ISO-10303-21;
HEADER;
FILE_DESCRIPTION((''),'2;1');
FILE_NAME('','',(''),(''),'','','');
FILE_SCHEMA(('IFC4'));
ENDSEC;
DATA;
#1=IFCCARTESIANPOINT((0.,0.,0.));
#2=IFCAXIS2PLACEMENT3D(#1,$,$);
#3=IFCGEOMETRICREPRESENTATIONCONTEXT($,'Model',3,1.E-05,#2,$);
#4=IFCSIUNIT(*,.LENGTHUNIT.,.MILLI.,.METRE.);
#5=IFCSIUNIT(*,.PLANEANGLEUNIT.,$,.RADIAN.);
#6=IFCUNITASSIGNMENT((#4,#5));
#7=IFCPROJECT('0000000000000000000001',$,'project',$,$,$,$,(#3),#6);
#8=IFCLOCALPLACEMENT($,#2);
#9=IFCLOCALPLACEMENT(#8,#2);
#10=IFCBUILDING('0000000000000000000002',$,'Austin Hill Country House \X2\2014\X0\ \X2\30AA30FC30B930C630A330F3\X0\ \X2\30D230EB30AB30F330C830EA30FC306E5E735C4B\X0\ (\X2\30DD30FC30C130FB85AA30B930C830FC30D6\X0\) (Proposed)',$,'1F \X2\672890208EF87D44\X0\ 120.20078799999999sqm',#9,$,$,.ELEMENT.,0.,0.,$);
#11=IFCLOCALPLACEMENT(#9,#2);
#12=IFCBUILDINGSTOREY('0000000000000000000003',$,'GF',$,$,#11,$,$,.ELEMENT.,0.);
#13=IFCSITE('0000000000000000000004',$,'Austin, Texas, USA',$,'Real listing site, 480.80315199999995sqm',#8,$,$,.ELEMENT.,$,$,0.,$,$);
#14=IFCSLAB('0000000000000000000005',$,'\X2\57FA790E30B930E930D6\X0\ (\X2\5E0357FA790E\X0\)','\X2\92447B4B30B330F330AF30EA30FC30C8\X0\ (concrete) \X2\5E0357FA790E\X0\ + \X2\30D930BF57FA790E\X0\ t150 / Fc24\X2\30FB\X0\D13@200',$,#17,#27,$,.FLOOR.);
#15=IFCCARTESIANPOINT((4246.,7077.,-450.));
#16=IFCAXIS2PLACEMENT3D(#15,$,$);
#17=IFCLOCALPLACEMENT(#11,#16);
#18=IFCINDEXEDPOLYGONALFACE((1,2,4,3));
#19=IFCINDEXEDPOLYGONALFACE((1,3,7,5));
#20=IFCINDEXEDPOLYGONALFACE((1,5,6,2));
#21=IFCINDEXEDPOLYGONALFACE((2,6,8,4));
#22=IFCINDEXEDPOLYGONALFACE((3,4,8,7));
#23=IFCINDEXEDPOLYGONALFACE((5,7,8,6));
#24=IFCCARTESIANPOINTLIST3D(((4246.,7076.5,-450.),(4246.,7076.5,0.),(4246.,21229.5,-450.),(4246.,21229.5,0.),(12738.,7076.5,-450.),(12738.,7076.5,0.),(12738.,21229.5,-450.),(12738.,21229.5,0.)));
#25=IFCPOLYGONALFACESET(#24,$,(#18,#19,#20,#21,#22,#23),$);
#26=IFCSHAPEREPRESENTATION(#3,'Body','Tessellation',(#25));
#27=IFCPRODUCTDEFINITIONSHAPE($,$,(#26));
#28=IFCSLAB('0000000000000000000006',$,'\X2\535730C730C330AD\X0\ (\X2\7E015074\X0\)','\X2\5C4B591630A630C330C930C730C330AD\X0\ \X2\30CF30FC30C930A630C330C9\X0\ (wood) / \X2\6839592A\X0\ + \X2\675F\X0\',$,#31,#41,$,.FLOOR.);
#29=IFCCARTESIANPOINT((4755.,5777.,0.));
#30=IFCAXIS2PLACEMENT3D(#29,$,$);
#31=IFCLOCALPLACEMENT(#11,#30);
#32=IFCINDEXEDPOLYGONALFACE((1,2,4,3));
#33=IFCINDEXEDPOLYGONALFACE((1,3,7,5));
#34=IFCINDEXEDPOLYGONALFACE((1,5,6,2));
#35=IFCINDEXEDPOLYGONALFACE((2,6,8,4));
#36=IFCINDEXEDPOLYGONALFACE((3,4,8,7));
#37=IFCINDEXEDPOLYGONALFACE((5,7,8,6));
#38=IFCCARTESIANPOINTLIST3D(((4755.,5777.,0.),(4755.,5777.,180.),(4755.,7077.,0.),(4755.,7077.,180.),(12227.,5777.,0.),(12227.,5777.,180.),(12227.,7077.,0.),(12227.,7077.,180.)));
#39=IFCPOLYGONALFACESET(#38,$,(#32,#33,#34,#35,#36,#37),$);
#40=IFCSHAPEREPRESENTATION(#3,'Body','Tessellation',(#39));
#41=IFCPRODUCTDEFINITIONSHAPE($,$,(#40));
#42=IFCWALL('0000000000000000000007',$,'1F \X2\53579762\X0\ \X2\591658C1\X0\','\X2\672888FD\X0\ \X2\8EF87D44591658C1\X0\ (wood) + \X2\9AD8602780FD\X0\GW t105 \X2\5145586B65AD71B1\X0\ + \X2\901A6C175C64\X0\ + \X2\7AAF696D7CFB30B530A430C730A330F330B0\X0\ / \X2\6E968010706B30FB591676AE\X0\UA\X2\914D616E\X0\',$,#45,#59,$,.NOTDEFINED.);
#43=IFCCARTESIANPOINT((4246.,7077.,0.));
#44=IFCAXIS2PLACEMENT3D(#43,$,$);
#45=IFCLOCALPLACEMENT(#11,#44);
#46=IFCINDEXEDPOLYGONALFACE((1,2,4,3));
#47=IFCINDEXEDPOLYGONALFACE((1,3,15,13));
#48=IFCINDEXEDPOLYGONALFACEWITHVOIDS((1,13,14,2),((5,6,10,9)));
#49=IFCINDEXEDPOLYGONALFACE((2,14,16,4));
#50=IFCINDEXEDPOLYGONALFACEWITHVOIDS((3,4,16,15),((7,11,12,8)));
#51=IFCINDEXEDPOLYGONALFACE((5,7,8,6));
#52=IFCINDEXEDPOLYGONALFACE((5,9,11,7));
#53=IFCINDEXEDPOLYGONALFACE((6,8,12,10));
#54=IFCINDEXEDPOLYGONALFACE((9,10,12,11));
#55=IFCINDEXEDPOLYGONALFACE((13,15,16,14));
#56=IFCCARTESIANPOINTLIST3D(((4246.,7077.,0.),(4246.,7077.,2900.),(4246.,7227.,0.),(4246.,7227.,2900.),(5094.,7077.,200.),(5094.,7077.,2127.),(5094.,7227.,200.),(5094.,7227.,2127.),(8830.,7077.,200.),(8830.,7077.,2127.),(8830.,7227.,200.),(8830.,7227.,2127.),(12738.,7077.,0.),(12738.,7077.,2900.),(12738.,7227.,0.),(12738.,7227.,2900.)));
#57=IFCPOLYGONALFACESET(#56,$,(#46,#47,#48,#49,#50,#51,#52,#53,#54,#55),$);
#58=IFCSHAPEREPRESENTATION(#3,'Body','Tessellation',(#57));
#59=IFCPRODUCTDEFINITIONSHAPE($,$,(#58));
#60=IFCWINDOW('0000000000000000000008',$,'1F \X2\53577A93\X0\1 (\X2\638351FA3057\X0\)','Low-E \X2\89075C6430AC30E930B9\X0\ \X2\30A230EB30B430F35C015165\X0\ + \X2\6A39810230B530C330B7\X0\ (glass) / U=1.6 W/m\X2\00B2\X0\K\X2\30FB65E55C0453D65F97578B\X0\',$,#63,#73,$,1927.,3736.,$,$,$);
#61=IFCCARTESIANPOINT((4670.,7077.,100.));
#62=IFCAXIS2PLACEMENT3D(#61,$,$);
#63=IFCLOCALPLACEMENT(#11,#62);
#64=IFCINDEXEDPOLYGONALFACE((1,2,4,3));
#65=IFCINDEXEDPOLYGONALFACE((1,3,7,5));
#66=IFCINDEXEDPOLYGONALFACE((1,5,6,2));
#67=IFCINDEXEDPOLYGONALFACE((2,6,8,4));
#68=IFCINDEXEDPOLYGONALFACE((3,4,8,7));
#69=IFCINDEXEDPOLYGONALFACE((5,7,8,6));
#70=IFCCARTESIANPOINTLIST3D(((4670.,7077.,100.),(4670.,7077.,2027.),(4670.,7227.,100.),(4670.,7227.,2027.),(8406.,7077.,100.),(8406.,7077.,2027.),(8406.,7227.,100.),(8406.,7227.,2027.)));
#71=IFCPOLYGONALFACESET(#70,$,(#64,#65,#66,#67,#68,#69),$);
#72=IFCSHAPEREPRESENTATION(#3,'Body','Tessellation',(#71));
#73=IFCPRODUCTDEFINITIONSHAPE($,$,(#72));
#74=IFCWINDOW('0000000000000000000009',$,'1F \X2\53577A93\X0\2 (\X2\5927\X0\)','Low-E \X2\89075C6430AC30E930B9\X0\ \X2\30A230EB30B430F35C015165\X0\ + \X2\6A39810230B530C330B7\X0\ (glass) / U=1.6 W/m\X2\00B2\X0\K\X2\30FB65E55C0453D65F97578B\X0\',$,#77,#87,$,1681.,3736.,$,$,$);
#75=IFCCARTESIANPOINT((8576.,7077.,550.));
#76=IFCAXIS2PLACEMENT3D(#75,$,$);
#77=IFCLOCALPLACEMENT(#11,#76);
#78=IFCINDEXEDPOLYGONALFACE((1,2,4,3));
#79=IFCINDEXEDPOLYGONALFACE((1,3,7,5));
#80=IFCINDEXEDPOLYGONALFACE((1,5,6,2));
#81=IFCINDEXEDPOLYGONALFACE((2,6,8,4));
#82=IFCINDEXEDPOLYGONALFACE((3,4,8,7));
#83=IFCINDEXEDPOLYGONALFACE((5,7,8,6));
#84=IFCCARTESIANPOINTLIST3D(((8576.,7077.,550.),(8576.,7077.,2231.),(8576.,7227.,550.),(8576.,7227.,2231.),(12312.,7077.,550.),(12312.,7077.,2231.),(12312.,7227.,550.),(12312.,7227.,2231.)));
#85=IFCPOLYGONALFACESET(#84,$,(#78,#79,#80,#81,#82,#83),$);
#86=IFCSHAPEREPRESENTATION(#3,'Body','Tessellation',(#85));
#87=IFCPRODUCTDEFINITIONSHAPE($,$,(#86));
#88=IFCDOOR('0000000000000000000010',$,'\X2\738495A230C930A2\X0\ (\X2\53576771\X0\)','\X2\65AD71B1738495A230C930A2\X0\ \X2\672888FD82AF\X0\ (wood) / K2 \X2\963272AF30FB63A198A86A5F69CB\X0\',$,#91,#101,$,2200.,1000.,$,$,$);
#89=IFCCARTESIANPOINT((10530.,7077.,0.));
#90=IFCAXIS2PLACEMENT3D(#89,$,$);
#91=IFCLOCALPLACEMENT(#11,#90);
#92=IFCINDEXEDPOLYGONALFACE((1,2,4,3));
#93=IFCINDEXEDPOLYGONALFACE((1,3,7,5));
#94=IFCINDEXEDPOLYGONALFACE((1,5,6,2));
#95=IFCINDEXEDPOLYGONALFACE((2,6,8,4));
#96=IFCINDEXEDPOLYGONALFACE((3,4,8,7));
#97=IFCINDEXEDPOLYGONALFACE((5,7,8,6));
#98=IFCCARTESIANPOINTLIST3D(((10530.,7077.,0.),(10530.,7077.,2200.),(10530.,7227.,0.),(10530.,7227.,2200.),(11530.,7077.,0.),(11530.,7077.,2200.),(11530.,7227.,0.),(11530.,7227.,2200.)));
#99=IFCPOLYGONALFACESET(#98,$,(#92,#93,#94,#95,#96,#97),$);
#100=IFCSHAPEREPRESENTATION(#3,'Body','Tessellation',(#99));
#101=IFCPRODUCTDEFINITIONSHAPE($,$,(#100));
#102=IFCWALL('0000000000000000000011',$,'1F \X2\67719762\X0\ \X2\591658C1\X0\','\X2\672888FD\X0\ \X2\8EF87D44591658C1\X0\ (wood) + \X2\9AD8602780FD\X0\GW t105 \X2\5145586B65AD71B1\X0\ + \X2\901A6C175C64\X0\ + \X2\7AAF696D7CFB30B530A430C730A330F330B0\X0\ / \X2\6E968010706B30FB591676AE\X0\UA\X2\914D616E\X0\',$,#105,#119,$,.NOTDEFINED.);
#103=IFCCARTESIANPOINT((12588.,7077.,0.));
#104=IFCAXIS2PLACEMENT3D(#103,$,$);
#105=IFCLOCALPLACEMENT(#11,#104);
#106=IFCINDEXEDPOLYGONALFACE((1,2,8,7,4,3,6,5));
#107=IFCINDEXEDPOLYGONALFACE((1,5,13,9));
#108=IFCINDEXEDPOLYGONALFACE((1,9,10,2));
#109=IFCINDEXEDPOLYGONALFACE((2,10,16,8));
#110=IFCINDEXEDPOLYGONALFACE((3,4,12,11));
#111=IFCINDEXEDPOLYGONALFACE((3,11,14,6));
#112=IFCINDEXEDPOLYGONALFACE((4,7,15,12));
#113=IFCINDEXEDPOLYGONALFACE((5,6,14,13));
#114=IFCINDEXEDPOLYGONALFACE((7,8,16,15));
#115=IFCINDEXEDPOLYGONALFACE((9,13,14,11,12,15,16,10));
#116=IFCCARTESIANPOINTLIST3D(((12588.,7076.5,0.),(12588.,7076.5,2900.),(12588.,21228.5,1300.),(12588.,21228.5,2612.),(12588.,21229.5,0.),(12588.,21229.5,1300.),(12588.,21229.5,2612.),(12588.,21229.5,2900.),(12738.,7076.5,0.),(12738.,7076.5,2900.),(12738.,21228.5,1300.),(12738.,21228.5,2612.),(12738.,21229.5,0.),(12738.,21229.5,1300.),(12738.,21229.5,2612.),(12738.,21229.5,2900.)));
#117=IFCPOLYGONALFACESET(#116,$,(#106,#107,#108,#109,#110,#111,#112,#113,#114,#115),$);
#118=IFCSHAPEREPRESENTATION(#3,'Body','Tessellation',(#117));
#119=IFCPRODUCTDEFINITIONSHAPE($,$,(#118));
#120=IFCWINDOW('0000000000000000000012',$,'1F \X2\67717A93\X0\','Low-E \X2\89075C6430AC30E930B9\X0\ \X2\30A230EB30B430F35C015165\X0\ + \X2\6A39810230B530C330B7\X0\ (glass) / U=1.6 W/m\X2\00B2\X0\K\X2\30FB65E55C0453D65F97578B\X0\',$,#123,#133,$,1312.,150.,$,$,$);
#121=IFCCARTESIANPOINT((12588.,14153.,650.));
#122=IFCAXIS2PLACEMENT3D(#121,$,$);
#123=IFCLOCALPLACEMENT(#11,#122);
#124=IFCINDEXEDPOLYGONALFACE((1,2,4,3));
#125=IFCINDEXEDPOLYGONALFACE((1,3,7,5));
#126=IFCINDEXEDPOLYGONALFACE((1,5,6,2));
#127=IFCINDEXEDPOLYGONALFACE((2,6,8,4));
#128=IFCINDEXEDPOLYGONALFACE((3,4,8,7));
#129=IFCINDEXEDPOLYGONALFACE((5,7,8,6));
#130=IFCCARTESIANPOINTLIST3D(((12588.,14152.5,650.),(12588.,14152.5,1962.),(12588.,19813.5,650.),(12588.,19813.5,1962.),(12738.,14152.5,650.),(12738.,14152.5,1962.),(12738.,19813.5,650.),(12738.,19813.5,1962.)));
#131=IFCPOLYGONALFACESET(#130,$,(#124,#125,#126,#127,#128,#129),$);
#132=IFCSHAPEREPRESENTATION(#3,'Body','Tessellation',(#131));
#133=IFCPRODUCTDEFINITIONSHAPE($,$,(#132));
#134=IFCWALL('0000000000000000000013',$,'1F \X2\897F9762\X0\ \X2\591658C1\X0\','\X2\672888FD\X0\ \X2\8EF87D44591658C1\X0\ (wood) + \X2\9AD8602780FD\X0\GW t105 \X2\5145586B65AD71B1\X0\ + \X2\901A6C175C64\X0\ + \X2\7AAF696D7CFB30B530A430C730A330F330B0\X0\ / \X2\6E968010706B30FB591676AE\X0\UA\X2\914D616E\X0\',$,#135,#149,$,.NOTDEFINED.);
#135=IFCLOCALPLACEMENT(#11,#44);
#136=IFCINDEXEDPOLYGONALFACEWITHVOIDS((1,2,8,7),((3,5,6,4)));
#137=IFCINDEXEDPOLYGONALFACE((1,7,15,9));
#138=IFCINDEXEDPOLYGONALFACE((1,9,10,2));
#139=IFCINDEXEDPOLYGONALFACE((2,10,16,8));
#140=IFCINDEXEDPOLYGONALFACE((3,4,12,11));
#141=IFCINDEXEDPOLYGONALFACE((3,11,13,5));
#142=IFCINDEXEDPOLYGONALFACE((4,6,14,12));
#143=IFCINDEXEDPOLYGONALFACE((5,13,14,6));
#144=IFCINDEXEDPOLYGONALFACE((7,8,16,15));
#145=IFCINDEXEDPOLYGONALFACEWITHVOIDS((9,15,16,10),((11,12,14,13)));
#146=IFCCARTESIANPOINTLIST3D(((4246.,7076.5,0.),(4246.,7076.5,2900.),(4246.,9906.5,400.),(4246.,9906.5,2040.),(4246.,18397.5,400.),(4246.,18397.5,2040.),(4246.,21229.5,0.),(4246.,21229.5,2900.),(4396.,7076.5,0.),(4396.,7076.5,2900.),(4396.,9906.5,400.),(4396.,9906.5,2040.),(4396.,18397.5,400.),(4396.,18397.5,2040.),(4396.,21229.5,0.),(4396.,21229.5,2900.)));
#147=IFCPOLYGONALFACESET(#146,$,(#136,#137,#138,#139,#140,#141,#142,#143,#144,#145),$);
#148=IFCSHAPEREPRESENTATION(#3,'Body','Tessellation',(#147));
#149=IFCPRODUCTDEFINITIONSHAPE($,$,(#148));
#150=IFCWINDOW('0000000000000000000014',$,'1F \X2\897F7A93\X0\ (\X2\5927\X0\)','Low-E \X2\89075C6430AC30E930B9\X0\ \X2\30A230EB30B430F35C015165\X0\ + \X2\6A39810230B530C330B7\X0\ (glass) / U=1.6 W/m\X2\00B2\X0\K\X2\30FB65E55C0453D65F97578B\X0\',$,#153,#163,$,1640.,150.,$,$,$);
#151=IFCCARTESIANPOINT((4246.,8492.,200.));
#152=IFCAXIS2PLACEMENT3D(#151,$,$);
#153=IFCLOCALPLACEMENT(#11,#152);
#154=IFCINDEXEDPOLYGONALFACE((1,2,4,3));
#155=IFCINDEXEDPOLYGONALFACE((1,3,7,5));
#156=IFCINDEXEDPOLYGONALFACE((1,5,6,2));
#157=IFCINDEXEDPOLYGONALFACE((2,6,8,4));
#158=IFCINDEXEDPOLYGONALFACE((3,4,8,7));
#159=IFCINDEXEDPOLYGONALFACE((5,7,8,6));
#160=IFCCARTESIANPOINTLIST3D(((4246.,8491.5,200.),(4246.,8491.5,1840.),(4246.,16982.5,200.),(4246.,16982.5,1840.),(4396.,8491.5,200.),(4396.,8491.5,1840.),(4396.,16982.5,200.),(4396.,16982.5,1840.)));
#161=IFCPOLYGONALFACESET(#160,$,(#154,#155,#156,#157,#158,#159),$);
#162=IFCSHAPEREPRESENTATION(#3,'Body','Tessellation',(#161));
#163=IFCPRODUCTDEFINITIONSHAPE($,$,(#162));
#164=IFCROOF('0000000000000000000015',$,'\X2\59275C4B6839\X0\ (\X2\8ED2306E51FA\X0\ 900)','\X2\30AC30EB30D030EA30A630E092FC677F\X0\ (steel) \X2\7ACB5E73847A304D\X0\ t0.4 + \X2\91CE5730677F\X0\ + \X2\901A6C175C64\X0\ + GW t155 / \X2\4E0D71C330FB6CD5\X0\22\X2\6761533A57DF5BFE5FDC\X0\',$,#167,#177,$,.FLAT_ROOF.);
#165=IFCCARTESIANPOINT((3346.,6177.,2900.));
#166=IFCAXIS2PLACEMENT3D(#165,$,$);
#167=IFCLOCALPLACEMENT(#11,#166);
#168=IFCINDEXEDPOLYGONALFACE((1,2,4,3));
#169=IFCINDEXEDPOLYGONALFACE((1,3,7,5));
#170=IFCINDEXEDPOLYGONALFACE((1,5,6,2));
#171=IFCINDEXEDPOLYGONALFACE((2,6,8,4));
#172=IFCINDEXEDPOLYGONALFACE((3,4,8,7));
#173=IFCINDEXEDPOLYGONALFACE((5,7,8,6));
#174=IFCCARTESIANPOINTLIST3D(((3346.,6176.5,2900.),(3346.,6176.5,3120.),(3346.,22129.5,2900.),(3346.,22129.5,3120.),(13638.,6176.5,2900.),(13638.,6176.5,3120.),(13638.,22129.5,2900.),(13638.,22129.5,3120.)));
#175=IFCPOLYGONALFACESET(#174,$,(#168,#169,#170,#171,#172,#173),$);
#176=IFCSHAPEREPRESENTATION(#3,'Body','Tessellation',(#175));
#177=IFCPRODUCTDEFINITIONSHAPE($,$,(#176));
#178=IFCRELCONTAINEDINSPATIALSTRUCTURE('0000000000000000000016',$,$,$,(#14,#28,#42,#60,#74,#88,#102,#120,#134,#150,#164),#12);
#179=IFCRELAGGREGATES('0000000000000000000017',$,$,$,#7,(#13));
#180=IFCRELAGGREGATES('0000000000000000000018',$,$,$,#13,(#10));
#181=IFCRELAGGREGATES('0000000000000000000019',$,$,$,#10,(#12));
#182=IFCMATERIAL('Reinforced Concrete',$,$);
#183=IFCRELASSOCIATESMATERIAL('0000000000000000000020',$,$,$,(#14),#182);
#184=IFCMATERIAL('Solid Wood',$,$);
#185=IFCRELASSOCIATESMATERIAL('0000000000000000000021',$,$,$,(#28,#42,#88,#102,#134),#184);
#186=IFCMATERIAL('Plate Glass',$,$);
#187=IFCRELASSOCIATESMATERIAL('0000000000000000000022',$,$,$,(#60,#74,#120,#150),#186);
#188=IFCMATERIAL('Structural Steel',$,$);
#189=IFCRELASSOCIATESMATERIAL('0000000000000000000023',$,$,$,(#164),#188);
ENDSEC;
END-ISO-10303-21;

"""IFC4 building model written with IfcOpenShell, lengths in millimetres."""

from ifc_helpers import new_model, si_unit, frame, frame_2d, origin, place, context, project, spatial, rectangle, extrude, material, element, fill, save


model = new_model("IFC4")

# Units and contexts
model_context = context("Model", 3, precision=1e-05, world=origin())
ifc_project = project(units=[si_unit("LENGTHUNIT", "METRE", prefix="MILLI"), si_unit("PLANEANGLEUNIT", "RADIAN")], contexts=[model_context])

# Site, building, storey
site_placement = place(None, origin())
site = spatial("IfcSite", under=ifc_project, at=site_placement, Name="Austin, Texas, USA", ObjectType="Real listing site, 480.80315199999995sqm", CompositionType="ELEMENT", RefElevation=0.0)
building_placement = place(site_placement, origin())
building = spatial("IfcBuilding", under=site, at=building_placement, Name="Austin Hill Country House — オースティン ヒルカントリーの平屋 (ポーチ・薪ストーブ) (Proposed)", ObjectType="1F 木造軸組 120.20078799999999sqm", CompositionType="ELEMENT", ElevationOfRefHeight=0.0, ElevationOfTerrain=0.0)
storey_placement = place(building_placement, origin())
storey = spatial("IfcBuildingStorey", under=building, at=storey_placement, Name="GF", CompositionType="ELEMENT", Elevation=0.0)

# Slabs
ifc_material_1 = material(Name="Reinforced Concrete")
slab_1_placement = place(storey_placement, frame((4246.0, 7077.0, -450.0)))
element("IfcSlab", 1, at=slab_1_placement, inside=storey, material=ifc_material_1, Name="基礎スラブ (布基礎)", Description="鉄筋コンクリート (concrete) 布基礎 + ベタ基礎 t150 / Fc24・D13@200", PredefinedType="FLOOR", context=model_context, shape_type="SweptSolid", body=[
    extrude(rectangle(XDim=8492.0, YDim=14153.0, at=frame_2d((4246.0, 7076.0))), frame((4246.0, 7077.0, -450.0)), (0.0, 0.0, 1.0), 450.0),
])
ifc_material_2 = material(Name="Solid Wood")
slab_2_placement = place(storey_placement, frame((4755.0, 5777.0, 0.0)))
element("IfcSlab", 2, at=slab_2_placement, inside=storey, material=ifc_material_2, Name="南デッキ (縁側)", Description="屋外ウッドデッキ ハードウッド (wood) / 根太 + 束", PredefinedType="FLOOR", context=model_context, shape_type="SweptSolid", body=[
    extrude(rectangle(XDim=7472.0, YDim=1300.0, at=frame_2d((3736.0, 650.0))), frame((4755.0, 5777.0, 0.0)), (0.0, 0.0, 1.0), 180.0),
])

# Wall, openings, windows, door
wall_1_placement = place(storey_placement, frame((4246.0, 7077.0, 0.0)))
wall_1 = element("IfcWall", 3, at=wall_1_placement, inside=storey, material=ifc_material_2, Name="1F 南面 外壁", Description="木製 軸組外壁 (wood) + 高性能GW t105 充填断熱 + 通気層 + 窯業系サイディング / 準耐火・外皮UA配慮", PredefinedType="NOTDEFINED", context=model_context, shape_type="SweptSolid", body=[
    extrude(rectangle(XDim=8492.0, YDim=150.0, at=frame_2d((4246.0, 75.0))), frame((4246.0, 7077.0, 0.0)), (0.0, 0.0, 1.0), 2900.0),
])
opening_1_placement = place(storey_placement, frame((4670.0, 7077.0, 100.0)))
opening_1 = element("IfcOpeningElement", 4, at=opening_1_placement, cuts=wall_1, PredefinedType="NOTDEFINED", context=model_context, shape_type="SweptSolid", body=[
    extrude(rectangle(XDim=3736.0, YDim=150.0, at=frame_2d((1868.0, 75.0))), frame((4670.0, 7077.0, 100.0)), (0.0, 0.0, 1.0), 1927.0),
])
opening_2_placement = place(storey_placement, frame((8576.0, 7077.0, 550.0)))
opening_2 = element("IfcOpeningElement", 5, at=opening_2_placement, cuts=wall_1, PredefinedType="NOTDEFINED", context=model_context, shape_type="SweptSolid", body=[
    extrude(rectangle(XDim=3736.0, YDim=150.0, at=frame_2d((1868.0, 75.0))), frame((8576.0, 7077.0, 550.0)), (0.0, 0.0, 1.0), 1681.0),
])
opening_3_placement = place(storey_placement, frame((10530.0, 7077.0, 0.0)))
opening_3 = element("IfcOpeningElement", 6, at=opening_3_placement, cuts=wall_1, PredefinedType="NOTDEFINED", context=model_context, shape_type="SweptSolid", body=[
    extrude(rectangle(XDim=1000.0, YDim=150.0, at=frame_2d((500.0, 75.0))), frame((10530.0, 7077.0, 0.0)), (0.0, 0.0, 1.0), 2200.0),
])
ifc_material_3 = material(Name="Plate Glass")
window_1_placement = place(storey_placement, frame((4670.0, 7077.0, 100.0)))
window_1 = element("IfcWindow", 7, at=window_1_placement, inside=storey, material=ifc_material_3, Name="1F 南窓1 (掃出し)", Description="Low-E 複層ガラス アルゴン封入 + 樹脂サッシ (glass) / U=1.6 W/m²K・日射取得型", OverallHeight=1927.0, OverallWidth=3736.0, context=model_context, shape_type="SweptSolid", body=[
    extrude(rectangle(XDim=3736.0, YDim=150.0, at=frame_2d((1868.0, 75.0))), frame((4670.0, 7077.0, 100.0)), (0.0, 0.0, 1.0), 1927.0),
])
fill(opening_1, window_1)
window_2_placement = place(storey_placement, frame((8576.0, 7077.0, 550.0)))
window_2 = element("IfcWindow", 8, at=window_2_placement, inside=storey, material=ifc_material_3, Name="1F 南窓2 (大)", Description="Low-E 複層ガラス アルゴン封入 + 樹脂サッシ (glass) / U=1.6 W/m²K・日射取得型", OverallHeight=1681.0, OverallWidth=3736.0, context=model_context, shape_type="SweptSolid", body=[
    extrude(rectangle(XDim=3736.0, YDim=150.0, at=frame_2d((1868.0, 75.0))), frame((8576.0, 7077.0, 550.0)), (0.0, 0.0, 1.0), 1681.0),
])
fill(opening_2, window_2)
door_placement = place(storey_placement, frame((10530.0, 7077.0, 0.0)))
door = element("IfcDoor", 9, at=door_placement, inside=storey, material=ifc_material_2, Name="玄関ドア (南東)", Description="断熱玄関ドア 木製芯 (wood) / K2 防犯・採風機構", OverallHeight=2200.0, OverallWidth=1000.0, context=model_context, shape_type="SweptSolid", body=[
    extrude(rectangle(XDim=1000.0, YDim=150.0, at=frame_2d((500.0, 75.0))), frame((10530.0, 7077.0, 0.0)), (0.0, 0.0, 1.0), 2200.0),
])
fill(opening_3, door)

# Walls, openings, windows
wall_2_placement = place(storey_placement, frame((12588.0, 7077.0, 0.0)))
wall_2 = element("IfcWall", 10, at=wall_2_placement, inside=storey, material=ifc_material_2, Name="1F 東面 外壁", Description="木製 軸組外壁 (wood) + 高性能GW t105 充填断熱 + 通気層 + 窯業系サイディング / 準耐火・外皮UA配慮", PredefinedType="NOTDEFINED", context=model_context, shape_type="SweptSolid", body=[
    extrude(rectangle(XDim=150.0, YDim=14153.0, at=frame_2d((75.0, 7076.0))), frame((12588.0, 7077.0, 0.0)), (0.0, 0.0, 1.0), 2900.0),
])
opening_4_placement = place(storey_placement, frame((12588.0, 14153.0, 650.0)))
opening_4 = element("IfcOpeningElement", 11, at=opening_4_placement, cuts=wall_2, PredefinedType="NOTDEFINED", context=model_context, shape_type="SweptSolid", body=[
    extrude(rectangle(XDim=150.0, YDim=5661.0, at=frame_2d((75.0, 2830.0))), frame((12588.0, 14153.0, 650.0)), (0.0, 0.0, 1.0), 1312.0),
])
window_3_placement = place(storey_placement, frame((12588.0, 14153.0, 650.0)))
window_3 = element("IfcWindow", 12, at=window_3_placement, inside=storey, material=ifc_material_3, Name="1F 東窓", Description="Low-E 複層ガラス アルゴン封入 + 樹脂サッシ (glass) / U=1.6 W/m²K・日射取得型", OverallHeight=1312.0, OverallWidth=150.0, context=model_context, shape_type="SweptSolid", body=[
    extrude(rectangle(XDim=150.0, YDim=5661.0, at=frame_2d((75.0, 2830.0))), frame((12588.0, 14153.0, 650.0)), (0.0, 0.0, 1.0), 1312.0),
])
fill(opening_4, window_3)
wall_3_placement = place(storey_placement, frame((4246.0, 7077.0, 0.0)))
wall_3 = element("IfcWall", 13, at=wall_3_placement, inside=storey, material=ifc_material_2, Name="1F 西面 外壁", Description="木製 軸組外壁 (wood) + 高性能GW t105 充填断熱 + 通気層 + 窯業系サイディング / 準耐火・外皮UA配慮", PredefinedType="NOTDEFINED", context=model_context, shape_type="SweptSolid", body=[
    extrude(rectangle(XDim=150.0, YDim=14153.0, at=frame_2d((75.0, 7076.0))), frame((4246.0, 7077.0, 0.0)), (0.0, 0.0, 1.0), 2900.0),
])
opening_5_placement = place(storey_placement, frame((4246.0, 8492.0, 200.0)))
opening_5 = element("IfcOpeningElement", 14, at=opening_5_placement, cuts=wall_3, PredefinedType="NOTDEFINED", context=model_context, shape_type="SweptSolid", body=[
    extrude(rectangle(XDim=150.0, YDim=8491.0, at=frame_2d((75.0, 4245.0))), frame((4246.0, 8492.0, 200.0)), (0.0, 0.0, 1.0), 1640.0),
])
window_4_placement = place(storey_placement, frame((4246.0, 8492.0, 200.0)))
window_4 = element("IfcWindow", 15, at=window_4_placement, inside=storey, material=ifc_material_3, Name="1F 西窓 (大)", Description="Low-E 複層ガラス アルゴン封入 + 樹脂サッシ (glass) / U=1.6 W/m²K・日射取得型", OverallHeight=1640.0, OverallWidth=150.0, context=model_context, shape_type="SweptSolid", body=[
    extrude(rectangle(XDim=150.0, YDim=8491.0, at=frame_2d((75.0, 4245.0))), frame((4246.0, 8492.0, 200.0)), (0.0, 0.0, 1.0), 1640.0),
])
fill(opening_5, window_4)

# Roof
ifc_material_4 = material(Name="Structural Steel")
roof_placement = place(storey_placement, frame((3346.0, 6177.0, 2900.0)))
element("IfcRoof", 16, at=roof_placement, inside=storey, material=ifc_material_4, Name="大屋根 (軒の出 900)", Description="ガルバリウム鋼板 (steel) 立平葺き t0.4 + 野地板 + 通気層 + GW t155 / 不燃・法22条区域対応", PredefinedType="FLAT_ROOF", context=model_context, shape_type="SweptSolid", body=[
    extrude(rectangle(XDim=10292.0, YDim=15953.0, at=frame_2d((5146.0, 7976.0))), frame((3346.0, 6177.0, 2900.0)), (0.0, 0.0, 1.0), 220.0),
])

save(model, "model.ifc")
